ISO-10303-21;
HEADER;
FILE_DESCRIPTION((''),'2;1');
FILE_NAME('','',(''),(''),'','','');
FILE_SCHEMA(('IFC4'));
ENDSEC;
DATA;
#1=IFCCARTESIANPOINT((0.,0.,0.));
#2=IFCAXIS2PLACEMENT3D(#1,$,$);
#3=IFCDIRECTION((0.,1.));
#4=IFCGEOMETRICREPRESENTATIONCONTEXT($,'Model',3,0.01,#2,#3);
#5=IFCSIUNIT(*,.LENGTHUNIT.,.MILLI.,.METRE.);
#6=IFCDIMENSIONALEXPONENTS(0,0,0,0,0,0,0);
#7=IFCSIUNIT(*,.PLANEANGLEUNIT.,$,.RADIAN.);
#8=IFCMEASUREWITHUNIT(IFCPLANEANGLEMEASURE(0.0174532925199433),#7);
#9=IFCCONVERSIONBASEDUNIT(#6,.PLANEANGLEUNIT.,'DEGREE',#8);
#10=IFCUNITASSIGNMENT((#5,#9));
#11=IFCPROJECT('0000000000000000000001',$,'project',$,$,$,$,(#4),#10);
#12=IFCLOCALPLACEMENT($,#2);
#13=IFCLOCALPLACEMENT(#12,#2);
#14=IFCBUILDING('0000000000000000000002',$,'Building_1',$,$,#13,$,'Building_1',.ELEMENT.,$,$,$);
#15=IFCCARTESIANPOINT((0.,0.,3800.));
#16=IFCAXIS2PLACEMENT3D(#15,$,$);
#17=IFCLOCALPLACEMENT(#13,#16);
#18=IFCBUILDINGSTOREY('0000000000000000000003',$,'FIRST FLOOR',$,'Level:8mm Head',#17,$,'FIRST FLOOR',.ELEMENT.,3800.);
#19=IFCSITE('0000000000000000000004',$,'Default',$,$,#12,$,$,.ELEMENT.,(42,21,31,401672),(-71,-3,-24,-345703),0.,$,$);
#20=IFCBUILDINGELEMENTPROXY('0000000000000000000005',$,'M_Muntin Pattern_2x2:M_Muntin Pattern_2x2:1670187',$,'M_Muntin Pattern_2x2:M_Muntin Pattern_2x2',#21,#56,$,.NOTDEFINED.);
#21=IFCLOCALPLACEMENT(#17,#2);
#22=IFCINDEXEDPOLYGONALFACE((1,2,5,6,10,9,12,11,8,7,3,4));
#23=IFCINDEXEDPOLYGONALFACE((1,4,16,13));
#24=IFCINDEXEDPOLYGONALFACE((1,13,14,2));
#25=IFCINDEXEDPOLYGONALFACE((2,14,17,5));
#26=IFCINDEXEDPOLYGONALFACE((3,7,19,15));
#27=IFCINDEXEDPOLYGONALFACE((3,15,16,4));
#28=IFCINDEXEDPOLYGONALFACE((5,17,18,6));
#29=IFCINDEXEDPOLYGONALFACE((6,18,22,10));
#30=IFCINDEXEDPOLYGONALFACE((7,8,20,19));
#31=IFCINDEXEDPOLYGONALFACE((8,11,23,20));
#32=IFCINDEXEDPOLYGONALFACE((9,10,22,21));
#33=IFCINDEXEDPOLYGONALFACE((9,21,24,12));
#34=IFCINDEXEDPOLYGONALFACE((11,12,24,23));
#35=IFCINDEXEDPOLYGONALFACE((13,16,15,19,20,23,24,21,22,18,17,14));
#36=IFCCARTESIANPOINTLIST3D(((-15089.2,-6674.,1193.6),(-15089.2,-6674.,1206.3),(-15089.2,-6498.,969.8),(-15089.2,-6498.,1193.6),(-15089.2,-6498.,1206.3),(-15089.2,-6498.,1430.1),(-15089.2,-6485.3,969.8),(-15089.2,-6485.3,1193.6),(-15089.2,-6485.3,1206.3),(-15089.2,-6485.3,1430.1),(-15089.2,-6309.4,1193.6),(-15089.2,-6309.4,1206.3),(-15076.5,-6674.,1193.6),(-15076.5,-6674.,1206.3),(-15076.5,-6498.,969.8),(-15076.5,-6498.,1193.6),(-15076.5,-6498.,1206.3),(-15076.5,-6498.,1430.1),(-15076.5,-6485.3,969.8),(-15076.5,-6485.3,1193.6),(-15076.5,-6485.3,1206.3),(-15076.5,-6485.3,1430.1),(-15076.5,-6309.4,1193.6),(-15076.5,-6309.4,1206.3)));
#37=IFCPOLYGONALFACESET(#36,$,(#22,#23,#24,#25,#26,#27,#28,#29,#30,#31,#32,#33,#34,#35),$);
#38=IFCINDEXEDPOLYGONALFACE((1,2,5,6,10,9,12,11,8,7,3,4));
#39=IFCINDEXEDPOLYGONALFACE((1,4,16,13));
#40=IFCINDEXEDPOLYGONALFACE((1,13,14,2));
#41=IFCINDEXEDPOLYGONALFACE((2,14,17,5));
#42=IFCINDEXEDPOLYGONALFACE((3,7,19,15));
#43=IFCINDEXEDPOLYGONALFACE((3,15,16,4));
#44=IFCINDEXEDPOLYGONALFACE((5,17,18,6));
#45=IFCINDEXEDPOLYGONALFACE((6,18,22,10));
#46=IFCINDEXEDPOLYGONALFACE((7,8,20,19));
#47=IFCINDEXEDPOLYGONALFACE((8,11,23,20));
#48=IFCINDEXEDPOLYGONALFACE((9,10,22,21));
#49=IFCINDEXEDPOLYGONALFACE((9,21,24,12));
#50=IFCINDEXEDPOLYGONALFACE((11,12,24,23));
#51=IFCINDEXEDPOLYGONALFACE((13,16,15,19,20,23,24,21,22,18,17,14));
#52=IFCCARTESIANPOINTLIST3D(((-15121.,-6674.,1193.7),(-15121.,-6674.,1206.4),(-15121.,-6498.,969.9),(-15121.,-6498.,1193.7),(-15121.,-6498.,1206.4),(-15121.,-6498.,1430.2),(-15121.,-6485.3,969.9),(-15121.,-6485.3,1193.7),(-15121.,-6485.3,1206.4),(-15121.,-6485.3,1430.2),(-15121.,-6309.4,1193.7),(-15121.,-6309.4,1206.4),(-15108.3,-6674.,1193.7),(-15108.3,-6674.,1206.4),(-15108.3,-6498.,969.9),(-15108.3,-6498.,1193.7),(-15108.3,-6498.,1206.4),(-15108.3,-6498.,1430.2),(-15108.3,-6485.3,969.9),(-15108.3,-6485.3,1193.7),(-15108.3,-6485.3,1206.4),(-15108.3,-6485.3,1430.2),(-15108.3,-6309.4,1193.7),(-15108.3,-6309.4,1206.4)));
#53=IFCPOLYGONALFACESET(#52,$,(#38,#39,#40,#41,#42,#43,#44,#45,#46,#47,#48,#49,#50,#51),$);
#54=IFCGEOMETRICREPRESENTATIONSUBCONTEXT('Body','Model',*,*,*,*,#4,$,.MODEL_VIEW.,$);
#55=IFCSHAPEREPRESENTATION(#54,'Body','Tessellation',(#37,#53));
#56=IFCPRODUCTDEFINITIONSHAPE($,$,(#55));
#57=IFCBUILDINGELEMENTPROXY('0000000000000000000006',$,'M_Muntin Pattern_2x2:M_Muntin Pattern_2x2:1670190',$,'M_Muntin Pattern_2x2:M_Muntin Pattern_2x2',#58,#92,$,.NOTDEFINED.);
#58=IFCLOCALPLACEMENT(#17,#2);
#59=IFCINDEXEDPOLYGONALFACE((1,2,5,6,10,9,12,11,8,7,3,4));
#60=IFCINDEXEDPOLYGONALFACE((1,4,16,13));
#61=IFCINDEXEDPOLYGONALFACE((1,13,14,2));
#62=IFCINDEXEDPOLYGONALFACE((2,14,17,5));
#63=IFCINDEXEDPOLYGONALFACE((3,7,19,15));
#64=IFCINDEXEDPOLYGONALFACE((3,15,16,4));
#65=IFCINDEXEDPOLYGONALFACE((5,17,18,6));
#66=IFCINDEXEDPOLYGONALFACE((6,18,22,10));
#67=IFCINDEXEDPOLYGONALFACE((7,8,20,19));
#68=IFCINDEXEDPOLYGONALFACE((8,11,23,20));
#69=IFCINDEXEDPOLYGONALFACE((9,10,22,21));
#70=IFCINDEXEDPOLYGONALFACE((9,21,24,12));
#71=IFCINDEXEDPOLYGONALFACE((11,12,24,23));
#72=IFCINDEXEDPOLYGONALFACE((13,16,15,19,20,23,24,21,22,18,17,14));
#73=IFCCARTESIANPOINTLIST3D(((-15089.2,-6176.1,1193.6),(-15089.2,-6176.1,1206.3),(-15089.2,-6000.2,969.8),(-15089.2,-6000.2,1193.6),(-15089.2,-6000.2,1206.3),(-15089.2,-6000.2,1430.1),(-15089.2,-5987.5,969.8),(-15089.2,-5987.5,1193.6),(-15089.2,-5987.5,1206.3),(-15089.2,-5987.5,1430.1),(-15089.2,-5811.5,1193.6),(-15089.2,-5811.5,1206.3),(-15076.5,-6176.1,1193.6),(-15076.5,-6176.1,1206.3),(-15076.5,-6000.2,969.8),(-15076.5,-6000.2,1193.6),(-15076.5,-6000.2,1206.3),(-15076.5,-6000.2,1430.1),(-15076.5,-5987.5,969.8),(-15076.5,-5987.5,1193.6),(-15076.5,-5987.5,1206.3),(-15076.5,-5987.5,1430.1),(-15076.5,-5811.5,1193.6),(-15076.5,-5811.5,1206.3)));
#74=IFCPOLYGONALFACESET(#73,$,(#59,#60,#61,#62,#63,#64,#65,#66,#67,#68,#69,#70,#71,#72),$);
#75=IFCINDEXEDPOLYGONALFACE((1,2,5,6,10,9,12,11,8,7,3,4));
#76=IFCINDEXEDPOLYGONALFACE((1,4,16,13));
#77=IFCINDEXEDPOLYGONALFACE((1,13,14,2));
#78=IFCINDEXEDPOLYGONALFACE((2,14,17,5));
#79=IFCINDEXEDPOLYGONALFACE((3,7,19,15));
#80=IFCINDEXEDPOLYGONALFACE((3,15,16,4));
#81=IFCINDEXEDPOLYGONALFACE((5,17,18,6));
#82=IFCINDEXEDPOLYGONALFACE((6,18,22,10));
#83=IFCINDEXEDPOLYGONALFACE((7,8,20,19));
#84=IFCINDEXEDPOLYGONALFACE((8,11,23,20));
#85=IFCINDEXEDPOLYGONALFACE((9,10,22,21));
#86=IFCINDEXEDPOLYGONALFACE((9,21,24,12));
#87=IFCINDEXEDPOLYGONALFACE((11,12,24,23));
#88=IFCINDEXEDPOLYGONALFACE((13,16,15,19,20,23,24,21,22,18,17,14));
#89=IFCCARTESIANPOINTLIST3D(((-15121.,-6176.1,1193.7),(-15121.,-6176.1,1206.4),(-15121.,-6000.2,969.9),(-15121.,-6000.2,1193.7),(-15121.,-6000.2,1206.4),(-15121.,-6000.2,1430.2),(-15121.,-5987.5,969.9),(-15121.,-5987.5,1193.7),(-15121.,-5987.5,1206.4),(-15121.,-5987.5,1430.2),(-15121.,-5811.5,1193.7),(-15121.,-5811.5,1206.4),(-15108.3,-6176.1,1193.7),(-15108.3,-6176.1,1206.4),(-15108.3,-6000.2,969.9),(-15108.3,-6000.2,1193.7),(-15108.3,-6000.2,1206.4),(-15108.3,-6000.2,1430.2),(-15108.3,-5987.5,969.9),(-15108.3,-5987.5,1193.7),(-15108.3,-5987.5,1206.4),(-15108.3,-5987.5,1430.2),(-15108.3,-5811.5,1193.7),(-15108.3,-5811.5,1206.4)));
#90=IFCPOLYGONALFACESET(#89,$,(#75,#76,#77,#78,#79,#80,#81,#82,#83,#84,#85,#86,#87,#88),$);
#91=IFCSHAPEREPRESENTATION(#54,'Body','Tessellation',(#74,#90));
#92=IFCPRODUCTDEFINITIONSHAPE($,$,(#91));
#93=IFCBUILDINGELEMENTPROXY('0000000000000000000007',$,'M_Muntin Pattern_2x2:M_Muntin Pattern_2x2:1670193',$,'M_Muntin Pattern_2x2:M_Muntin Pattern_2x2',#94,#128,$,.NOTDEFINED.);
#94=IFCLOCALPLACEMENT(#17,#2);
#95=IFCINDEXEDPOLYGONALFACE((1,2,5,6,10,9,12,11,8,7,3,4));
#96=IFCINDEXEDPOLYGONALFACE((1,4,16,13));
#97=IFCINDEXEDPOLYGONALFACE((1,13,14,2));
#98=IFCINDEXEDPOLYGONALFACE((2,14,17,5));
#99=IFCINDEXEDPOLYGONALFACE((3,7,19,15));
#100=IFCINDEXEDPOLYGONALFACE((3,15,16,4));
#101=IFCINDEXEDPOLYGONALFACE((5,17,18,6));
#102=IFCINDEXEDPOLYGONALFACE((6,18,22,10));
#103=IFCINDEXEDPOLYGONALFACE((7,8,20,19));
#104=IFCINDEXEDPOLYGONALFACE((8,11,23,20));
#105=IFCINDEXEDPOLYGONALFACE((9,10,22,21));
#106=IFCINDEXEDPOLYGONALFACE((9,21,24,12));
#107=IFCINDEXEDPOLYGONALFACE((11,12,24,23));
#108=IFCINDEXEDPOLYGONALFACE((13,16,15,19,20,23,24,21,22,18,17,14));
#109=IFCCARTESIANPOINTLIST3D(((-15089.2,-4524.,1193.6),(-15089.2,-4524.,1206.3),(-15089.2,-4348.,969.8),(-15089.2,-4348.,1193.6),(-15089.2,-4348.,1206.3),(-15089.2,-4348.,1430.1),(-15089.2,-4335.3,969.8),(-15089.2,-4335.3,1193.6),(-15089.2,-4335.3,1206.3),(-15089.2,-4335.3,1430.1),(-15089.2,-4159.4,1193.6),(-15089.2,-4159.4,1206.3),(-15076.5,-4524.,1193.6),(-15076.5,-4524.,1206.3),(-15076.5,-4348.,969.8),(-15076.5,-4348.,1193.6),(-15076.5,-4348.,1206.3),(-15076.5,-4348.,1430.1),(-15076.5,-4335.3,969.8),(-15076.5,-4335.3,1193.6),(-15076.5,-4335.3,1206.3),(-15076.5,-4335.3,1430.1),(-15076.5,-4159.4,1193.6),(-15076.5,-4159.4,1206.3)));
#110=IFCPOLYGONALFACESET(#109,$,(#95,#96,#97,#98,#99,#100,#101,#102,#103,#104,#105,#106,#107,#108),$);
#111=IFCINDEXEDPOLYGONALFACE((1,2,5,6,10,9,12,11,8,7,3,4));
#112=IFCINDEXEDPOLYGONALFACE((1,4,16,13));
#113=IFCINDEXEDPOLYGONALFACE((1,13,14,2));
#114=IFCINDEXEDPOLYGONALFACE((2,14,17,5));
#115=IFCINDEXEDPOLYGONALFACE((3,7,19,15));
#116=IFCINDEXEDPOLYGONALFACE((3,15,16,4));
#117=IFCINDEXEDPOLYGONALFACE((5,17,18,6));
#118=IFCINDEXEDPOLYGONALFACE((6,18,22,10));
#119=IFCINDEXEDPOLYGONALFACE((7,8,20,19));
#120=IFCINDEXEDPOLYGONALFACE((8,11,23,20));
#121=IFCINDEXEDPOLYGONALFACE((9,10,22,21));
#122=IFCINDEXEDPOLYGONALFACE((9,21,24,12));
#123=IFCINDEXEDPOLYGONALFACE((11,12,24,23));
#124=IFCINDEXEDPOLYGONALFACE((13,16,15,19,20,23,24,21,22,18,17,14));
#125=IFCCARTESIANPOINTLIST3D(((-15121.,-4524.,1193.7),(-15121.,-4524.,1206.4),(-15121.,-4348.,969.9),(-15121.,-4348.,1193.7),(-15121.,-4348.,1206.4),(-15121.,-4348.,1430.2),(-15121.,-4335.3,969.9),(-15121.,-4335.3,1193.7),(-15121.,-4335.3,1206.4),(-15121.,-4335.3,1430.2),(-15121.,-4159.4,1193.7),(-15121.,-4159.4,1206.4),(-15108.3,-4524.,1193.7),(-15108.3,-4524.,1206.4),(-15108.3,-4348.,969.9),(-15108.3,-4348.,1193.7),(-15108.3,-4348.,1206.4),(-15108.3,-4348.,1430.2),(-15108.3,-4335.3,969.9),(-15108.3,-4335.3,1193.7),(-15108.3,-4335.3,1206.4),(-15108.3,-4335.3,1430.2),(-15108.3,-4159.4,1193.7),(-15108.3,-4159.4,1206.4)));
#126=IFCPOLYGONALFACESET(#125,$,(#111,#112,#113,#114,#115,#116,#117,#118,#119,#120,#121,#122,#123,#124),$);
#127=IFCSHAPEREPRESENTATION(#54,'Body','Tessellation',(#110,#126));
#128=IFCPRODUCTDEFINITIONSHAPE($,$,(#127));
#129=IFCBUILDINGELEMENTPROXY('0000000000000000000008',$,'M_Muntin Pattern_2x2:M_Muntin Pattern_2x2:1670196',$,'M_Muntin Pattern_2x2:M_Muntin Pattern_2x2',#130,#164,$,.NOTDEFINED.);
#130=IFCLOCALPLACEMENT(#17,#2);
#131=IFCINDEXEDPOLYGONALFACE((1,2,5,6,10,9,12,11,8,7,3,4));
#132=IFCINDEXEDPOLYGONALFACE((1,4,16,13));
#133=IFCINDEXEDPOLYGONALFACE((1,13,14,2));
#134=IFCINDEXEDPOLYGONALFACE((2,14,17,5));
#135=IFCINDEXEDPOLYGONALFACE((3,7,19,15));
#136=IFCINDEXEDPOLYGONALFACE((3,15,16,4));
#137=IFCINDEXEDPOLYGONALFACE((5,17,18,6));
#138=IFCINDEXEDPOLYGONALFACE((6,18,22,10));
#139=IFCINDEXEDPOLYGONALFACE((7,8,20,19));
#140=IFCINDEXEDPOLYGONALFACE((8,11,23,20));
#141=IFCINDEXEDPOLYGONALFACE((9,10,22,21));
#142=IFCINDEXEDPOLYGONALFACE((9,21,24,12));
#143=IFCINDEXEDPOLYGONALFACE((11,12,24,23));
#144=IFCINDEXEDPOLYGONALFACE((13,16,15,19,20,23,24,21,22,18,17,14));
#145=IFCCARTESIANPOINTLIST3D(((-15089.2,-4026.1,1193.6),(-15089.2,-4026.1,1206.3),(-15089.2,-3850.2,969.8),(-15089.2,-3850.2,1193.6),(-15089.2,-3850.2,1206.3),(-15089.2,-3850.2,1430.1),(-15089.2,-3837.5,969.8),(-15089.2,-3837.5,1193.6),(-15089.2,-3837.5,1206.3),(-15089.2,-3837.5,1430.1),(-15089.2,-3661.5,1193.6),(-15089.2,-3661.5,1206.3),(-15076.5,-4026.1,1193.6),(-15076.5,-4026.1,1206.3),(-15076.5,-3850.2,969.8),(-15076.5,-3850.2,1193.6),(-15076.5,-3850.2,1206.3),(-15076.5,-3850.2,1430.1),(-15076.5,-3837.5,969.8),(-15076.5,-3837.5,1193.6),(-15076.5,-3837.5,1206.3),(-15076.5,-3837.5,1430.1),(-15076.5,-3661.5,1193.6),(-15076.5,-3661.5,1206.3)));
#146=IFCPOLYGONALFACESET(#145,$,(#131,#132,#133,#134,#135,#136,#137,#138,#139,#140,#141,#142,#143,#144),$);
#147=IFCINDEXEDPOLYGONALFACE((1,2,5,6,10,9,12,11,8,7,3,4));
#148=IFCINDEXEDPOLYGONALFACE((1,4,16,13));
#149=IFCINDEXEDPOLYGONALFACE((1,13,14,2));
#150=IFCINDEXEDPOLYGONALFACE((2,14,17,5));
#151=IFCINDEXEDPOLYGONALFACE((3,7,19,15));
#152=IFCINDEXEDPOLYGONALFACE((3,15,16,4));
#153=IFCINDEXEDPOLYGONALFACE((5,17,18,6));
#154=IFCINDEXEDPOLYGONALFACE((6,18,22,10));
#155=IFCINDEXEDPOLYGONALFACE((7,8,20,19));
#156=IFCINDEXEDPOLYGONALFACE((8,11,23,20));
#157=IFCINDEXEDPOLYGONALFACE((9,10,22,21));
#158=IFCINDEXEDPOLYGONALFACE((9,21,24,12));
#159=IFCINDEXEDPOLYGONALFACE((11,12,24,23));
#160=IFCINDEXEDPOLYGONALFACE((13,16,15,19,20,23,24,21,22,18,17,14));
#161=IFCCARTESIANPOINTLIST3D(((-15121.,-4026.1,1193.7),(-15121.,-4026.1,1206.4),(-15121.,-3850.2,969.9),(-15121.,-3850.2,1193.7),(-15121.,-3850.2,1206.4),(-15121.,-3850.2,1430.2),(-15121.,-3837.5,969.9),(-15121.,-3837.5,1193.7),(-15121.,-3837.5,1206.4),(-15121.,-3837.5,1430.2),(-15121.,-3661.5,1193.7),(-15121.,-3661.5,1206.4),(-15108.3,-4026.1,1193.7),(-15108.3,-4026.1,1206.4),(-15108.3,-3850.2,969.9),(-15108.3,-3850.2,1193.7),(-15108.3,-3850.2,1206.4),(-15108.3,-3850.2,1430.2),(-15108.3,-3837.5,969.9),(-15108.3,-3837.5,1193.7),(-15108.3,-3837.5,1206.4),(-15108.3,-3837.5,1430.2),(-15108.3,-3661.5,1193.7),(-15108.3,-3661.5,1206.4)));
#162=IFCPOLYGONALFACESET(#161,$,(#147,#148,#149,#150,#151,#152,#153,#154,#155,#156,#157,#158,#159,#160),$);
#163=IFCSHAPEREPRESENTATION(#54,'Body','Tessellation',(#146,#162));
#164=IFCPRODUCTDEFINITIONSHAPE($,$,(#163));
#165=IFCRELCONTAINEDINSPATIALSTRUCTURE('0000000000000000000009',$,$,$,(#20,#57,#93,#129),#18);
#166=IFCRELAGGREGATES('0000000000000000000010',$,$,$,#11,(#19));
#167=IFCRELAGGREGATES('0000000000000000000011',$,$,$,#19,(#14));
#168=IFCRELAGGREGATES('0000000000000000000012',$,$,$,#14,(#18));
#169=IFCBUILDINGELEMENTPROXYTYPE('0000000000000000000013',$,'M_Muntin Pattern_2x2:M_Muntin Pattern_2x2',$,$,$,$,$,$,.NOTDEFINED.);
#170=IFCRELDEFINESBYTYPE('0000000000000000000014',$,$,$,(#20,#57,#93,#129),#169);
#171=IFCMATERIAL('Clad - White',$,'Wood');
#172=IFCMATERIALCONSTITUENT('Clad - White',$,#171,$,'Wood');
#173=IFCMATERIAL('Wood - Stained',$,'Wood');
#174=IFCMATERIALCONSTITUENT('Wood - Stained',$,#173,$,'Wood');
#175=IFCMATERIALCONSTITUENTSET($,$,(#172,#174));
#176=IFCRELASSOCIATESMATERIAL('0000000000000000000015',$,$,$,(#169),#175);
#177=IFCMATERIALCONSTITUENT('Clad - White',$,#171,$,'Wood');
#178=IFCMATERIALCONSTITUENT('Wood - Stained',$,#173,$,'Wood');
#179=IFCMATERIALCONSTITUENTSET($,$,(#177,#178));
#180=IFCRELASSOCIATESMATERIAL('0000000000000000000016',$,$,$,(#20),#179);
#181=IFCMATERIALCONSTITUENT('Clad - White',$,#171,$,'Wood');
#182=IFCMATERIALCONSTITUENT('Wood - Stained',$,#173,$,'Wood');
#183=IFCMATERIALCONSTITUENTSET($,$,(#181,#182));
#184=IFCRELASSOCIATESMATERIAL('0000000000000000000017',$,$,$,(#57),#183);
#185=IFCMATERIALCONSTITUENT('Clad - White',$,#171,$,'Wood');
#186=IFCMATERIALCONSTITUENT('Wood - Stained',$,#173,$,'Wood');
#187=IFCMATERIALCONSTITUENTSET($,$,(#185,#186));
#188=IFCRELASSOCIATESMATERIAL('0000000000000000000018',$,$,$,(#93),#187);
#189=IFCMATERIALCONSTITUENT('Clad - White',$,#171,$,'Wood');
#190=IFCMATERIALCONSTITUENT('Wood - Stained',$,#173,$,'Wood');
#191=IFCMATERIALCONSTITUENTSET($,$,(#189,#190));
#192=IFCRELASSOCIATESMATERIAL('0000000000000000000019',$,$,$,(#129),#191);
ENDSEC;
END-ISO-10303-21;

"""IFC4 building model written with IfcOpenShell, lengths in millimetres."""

from ifc_helpers import new_model, entity, si_unit, converted_unit, direction, frame, origin, place, context, subcontext, project, spatial, indexed_curve, outline, extrude, source, transform, mapped, material, constituent, constituent_set, type_object, type_shapes, element, save


model = new_model("IFC4")

# Units and contexts
model_context = context("Model", 3, precision=0.01, world=origin(), true_north=direction((0.0, 1.0)))
body_context = subcontext(model_context, "Body", "Model", "MODEL_VIEW")
ifc_project = project(units=[si_unit("LENGTHUNIT", "METRE", prefix="MILLI"), converted_unit("PLANEANGLEUNIT", "DEGREE", entity("IfcPlaneAngleMeasure", 0.0174532925199433), si_unit("PLANEANGLEUNIT", "RADIAN"), dimensions=[0, 0, 0, 0, 0, 0, 0])], contexts=[model_context])

# Site, building, storey
site_placement = place(None, origin())
site = spatial("IfcSite", under=ifc_project, at=site_placement, Name="Default", CompositionType="ELEMENT", RefLatitude=(42, 21, 31, 401672), RefLongitude=(-71, -3, -24, -345703), RefElevation=0.0)
building_placement = place(site_placement, origin())
building = spatial("IfcBuilding", under=site, at=building_placement, Name="Building_1", LongName="Building_1", CompositionType="ELEMENT")
storey_placement = place(building_placement, frame((0.0, 0.0, 3800.0)))
storey = spatial("IfcBuildingStorey", under=building, at=storey_placement, Name="FIRST FLOOR", ObjectType="Level:8mm Head", LongName="FIRST FLOOR", CompositionType="ELEMENT", Elevation=3800.0)

# Shared definitions
ifc_material_1 = material(Name="Wood - Stained", Category="Wood")

# Building element proxies
ifc_material_2 = material(Name="Clad - White", Category="Wood")
ifc_constituent_1 = constituent(ifc_material_2, Name="Clad - White", Category="Wood")
ifc_constituent_2 = constituent(ifc_material_1, Name="Wood - Stained", Category="Wood")
ifc_constituent_set_1 = constituent_set(constituents=[ifc_constituent_1, ifc_constituent_2])
ifc_constituent_3 = constituent(ifc_material_2, Name="Clad - White", Category="Wood")
ifc_constituent_4 = constituent(ifc_material_1, Name="Wood - Stained", Category="Wood")
ifc_constituent_set_2 = constituent_set(constituents=[ifc_constituent_3, ifc_constituent_4])
building_element_proxy_type_1 = type_object("IfcBuildingElementProxyType", Name="M_Muntin Pattern_2x2:M_Muntin Pattern_2x2", PredefinedType="NOTDEFINED", material=ifc_constituent_set_2)
shared_shape_1 = source(origin(), body_context, "Body", "SweptSolid", [
    extrude(outline(indexed_curve([(6.4, -6.4), (230.1, -6.4), (230.1, 6.3), (6.4, 6.3), (6.4, 182.3), (-6.3, 182.3), (-6.3, 6.3), (-230.2, 6.3), (-230.2, -6.4), (-6.3, -6.4), (-6.3, -182.3), (6.4, -182.3), (6.4, -6.4)], self_intersect=False)), frame((0.0, -22.2, 230.1), z_axis=(0.0, 1.0, 0.0), x_axis=(0.0, 0.0, 1.0)), (0.0, 0.0, 1.0), 12.7),
    extrude(outline(indexed_curve([(6.4, -6.4), (230.2, -6.4), (230.2, 6.3), (6.4, 6.3), (6.4, 182.3), (-6.3, 182.3), (-6.3, 6.3), (-230.2, 6.3), (-230.2, -6.4), (-6.3, -6.4), (-6.3, -182.3), (6.4, -182.3), (6.4, -6.4)], self_intersect=False)), frame((0.0, 9.5, 230.2), z_axis=(0.0, 1.0, 0.0), x_axis=(0.0, 0.0, 1.0)), (0.0, 0.0, 1.0), 12.7),
])
type_shapes(building_element_proxy_type_1, [shared_shape_1])
proxy_1_placement = place(storey_placement, frame((-15098.7, -6491.7, 969.9), z_axis=(0.0, 0.0, 1.0), x_axis=(0.0, 1.0, 0.0)))
element("IfcBuildingElementProxy", 1, at=proxy_1_placement, inside=storey, type_object=building_element_proxy_type_1, material=ifc_constituent_set_1, Name="M_Muntin Pattern_2x2:M_Muntin Pattern_2x2:1670187", ObjectType="M_Muntin Pattern_2x2:M_Muntin Pattern_2x2", PredefinedType="NOTDEFINED", context=body_context, shape_type="MappedRepresentation", body=[
    mapped(shared_shape_1, transform((0.0, 0.0, 0.0), scale=1.0)),
])
ifc_constituent_5 = constituent(ifc_material_2, Name="Clad - White", Category="Wood")
ifc_constituent_6 = constituent(ifc_material_1, Name="Wood - Stained", Category="Wood")
ifc_constituent_set_3 = constituent_set(constituents=[ifc_constituent_5, ifc_constituent_6])
proxy_2_placement = place(storey_placement, frame((-15098.7, -5993.8, 969.9), z_axis=(0.0, 0.0, 1.0), x_axis=(0.0, 1.0, 0.0)))
element("IfcBuildingElementProxy", 2, at=proxy_2_placement, inside=storey, type_object=building_element_proxy_type_1, material=ifc_constituent_set_3, Name="M_Muntin Pattern_2x2:M_Muntin Pattern_2x2:1670190", ObjectType="M_Muntin Pattern_2x2:M_Muntin Pattern_2x2", PredefinedType="NOTDEFINED", context=body_context, shape_type="MappedRepresentation", body=[
    mapped(shared_shape_1, transform((0.0, 0.0, 0.0), scale=1.0)),
])
ifc_constituent_7 = constituent(ifc_material_2, Name="Clad - White", Category="Wood")
ifc_constituent_8 = constituent(ifc_material_1, Name="Wood - Stained", Category="Wood")
ifc_constituent_set_4 = constituent_set(constituents=[ifc_constituent_7, ifc_constituent_8])
proxy_3_placement = place(storey_placement, frame((-15098.7, -4341.7, 969.9), z_axis=(0.0, 0.0, 1.0), x_axis=(0.0, 1.0, 0.0)))
element("IfcBuildingElementProxy", 3, at=proxy_3_placement, inside=storey, type_object=building_element_proxy_type_1, material=ifc_constituent_set_4, Name="M_Muntin Pattern_2x2:M_Muntin Pattern_2x2:1670193", ObjectType="M_Muntin Pattern_2x2:M_Muntin Pattern_2x2", PredefinedType="NOTDEFINED", context=body_context, shape_type="MappedRepresentation", body=[
    mapped(shared_shape_1, transform((0.0, 0.0, 0.0), scale=1.0)),
])
ifc_constituent_9 = constituent(ifc_material_2, Name="Clad - White", Category="Wood")
ifc_constituent_10 = constituent(ifc_material_1, Name="Wood - Stained", Category="Wood")
ifc_constituent_set_5 = constituent_set(constituents=[ifc_constituent_9, ifc_constituent_10])
proxy_4_placement = place(storey_placement, frame((-15098.7, -3843.8, 969.9), z_axis=(0.0, 0.0, 1.0), x_axis=(0.0, 1.0, 0.0)))
element("IfcBuildingElementProxy", 4, at=proxy_4_placement, inside=storey, type_object=building_element_proxy_type_1, material=ifc_constituent_set_5, Name="M_Muntin Pattern_2x2:M_Muntin Pattern_2x2:1670196", ObjectType="M_Muntin Pattern_2x2:M_Muntin Pattern_2x2", PredefinedType="NOTDEFINED", context=body_context, shape_type="MappedRepresentation", body=[
    mapped(shared_shape_1, transform((0.0, 0.0, 0.0), scale=1.0)),
])

save(model, "model.ifc")
